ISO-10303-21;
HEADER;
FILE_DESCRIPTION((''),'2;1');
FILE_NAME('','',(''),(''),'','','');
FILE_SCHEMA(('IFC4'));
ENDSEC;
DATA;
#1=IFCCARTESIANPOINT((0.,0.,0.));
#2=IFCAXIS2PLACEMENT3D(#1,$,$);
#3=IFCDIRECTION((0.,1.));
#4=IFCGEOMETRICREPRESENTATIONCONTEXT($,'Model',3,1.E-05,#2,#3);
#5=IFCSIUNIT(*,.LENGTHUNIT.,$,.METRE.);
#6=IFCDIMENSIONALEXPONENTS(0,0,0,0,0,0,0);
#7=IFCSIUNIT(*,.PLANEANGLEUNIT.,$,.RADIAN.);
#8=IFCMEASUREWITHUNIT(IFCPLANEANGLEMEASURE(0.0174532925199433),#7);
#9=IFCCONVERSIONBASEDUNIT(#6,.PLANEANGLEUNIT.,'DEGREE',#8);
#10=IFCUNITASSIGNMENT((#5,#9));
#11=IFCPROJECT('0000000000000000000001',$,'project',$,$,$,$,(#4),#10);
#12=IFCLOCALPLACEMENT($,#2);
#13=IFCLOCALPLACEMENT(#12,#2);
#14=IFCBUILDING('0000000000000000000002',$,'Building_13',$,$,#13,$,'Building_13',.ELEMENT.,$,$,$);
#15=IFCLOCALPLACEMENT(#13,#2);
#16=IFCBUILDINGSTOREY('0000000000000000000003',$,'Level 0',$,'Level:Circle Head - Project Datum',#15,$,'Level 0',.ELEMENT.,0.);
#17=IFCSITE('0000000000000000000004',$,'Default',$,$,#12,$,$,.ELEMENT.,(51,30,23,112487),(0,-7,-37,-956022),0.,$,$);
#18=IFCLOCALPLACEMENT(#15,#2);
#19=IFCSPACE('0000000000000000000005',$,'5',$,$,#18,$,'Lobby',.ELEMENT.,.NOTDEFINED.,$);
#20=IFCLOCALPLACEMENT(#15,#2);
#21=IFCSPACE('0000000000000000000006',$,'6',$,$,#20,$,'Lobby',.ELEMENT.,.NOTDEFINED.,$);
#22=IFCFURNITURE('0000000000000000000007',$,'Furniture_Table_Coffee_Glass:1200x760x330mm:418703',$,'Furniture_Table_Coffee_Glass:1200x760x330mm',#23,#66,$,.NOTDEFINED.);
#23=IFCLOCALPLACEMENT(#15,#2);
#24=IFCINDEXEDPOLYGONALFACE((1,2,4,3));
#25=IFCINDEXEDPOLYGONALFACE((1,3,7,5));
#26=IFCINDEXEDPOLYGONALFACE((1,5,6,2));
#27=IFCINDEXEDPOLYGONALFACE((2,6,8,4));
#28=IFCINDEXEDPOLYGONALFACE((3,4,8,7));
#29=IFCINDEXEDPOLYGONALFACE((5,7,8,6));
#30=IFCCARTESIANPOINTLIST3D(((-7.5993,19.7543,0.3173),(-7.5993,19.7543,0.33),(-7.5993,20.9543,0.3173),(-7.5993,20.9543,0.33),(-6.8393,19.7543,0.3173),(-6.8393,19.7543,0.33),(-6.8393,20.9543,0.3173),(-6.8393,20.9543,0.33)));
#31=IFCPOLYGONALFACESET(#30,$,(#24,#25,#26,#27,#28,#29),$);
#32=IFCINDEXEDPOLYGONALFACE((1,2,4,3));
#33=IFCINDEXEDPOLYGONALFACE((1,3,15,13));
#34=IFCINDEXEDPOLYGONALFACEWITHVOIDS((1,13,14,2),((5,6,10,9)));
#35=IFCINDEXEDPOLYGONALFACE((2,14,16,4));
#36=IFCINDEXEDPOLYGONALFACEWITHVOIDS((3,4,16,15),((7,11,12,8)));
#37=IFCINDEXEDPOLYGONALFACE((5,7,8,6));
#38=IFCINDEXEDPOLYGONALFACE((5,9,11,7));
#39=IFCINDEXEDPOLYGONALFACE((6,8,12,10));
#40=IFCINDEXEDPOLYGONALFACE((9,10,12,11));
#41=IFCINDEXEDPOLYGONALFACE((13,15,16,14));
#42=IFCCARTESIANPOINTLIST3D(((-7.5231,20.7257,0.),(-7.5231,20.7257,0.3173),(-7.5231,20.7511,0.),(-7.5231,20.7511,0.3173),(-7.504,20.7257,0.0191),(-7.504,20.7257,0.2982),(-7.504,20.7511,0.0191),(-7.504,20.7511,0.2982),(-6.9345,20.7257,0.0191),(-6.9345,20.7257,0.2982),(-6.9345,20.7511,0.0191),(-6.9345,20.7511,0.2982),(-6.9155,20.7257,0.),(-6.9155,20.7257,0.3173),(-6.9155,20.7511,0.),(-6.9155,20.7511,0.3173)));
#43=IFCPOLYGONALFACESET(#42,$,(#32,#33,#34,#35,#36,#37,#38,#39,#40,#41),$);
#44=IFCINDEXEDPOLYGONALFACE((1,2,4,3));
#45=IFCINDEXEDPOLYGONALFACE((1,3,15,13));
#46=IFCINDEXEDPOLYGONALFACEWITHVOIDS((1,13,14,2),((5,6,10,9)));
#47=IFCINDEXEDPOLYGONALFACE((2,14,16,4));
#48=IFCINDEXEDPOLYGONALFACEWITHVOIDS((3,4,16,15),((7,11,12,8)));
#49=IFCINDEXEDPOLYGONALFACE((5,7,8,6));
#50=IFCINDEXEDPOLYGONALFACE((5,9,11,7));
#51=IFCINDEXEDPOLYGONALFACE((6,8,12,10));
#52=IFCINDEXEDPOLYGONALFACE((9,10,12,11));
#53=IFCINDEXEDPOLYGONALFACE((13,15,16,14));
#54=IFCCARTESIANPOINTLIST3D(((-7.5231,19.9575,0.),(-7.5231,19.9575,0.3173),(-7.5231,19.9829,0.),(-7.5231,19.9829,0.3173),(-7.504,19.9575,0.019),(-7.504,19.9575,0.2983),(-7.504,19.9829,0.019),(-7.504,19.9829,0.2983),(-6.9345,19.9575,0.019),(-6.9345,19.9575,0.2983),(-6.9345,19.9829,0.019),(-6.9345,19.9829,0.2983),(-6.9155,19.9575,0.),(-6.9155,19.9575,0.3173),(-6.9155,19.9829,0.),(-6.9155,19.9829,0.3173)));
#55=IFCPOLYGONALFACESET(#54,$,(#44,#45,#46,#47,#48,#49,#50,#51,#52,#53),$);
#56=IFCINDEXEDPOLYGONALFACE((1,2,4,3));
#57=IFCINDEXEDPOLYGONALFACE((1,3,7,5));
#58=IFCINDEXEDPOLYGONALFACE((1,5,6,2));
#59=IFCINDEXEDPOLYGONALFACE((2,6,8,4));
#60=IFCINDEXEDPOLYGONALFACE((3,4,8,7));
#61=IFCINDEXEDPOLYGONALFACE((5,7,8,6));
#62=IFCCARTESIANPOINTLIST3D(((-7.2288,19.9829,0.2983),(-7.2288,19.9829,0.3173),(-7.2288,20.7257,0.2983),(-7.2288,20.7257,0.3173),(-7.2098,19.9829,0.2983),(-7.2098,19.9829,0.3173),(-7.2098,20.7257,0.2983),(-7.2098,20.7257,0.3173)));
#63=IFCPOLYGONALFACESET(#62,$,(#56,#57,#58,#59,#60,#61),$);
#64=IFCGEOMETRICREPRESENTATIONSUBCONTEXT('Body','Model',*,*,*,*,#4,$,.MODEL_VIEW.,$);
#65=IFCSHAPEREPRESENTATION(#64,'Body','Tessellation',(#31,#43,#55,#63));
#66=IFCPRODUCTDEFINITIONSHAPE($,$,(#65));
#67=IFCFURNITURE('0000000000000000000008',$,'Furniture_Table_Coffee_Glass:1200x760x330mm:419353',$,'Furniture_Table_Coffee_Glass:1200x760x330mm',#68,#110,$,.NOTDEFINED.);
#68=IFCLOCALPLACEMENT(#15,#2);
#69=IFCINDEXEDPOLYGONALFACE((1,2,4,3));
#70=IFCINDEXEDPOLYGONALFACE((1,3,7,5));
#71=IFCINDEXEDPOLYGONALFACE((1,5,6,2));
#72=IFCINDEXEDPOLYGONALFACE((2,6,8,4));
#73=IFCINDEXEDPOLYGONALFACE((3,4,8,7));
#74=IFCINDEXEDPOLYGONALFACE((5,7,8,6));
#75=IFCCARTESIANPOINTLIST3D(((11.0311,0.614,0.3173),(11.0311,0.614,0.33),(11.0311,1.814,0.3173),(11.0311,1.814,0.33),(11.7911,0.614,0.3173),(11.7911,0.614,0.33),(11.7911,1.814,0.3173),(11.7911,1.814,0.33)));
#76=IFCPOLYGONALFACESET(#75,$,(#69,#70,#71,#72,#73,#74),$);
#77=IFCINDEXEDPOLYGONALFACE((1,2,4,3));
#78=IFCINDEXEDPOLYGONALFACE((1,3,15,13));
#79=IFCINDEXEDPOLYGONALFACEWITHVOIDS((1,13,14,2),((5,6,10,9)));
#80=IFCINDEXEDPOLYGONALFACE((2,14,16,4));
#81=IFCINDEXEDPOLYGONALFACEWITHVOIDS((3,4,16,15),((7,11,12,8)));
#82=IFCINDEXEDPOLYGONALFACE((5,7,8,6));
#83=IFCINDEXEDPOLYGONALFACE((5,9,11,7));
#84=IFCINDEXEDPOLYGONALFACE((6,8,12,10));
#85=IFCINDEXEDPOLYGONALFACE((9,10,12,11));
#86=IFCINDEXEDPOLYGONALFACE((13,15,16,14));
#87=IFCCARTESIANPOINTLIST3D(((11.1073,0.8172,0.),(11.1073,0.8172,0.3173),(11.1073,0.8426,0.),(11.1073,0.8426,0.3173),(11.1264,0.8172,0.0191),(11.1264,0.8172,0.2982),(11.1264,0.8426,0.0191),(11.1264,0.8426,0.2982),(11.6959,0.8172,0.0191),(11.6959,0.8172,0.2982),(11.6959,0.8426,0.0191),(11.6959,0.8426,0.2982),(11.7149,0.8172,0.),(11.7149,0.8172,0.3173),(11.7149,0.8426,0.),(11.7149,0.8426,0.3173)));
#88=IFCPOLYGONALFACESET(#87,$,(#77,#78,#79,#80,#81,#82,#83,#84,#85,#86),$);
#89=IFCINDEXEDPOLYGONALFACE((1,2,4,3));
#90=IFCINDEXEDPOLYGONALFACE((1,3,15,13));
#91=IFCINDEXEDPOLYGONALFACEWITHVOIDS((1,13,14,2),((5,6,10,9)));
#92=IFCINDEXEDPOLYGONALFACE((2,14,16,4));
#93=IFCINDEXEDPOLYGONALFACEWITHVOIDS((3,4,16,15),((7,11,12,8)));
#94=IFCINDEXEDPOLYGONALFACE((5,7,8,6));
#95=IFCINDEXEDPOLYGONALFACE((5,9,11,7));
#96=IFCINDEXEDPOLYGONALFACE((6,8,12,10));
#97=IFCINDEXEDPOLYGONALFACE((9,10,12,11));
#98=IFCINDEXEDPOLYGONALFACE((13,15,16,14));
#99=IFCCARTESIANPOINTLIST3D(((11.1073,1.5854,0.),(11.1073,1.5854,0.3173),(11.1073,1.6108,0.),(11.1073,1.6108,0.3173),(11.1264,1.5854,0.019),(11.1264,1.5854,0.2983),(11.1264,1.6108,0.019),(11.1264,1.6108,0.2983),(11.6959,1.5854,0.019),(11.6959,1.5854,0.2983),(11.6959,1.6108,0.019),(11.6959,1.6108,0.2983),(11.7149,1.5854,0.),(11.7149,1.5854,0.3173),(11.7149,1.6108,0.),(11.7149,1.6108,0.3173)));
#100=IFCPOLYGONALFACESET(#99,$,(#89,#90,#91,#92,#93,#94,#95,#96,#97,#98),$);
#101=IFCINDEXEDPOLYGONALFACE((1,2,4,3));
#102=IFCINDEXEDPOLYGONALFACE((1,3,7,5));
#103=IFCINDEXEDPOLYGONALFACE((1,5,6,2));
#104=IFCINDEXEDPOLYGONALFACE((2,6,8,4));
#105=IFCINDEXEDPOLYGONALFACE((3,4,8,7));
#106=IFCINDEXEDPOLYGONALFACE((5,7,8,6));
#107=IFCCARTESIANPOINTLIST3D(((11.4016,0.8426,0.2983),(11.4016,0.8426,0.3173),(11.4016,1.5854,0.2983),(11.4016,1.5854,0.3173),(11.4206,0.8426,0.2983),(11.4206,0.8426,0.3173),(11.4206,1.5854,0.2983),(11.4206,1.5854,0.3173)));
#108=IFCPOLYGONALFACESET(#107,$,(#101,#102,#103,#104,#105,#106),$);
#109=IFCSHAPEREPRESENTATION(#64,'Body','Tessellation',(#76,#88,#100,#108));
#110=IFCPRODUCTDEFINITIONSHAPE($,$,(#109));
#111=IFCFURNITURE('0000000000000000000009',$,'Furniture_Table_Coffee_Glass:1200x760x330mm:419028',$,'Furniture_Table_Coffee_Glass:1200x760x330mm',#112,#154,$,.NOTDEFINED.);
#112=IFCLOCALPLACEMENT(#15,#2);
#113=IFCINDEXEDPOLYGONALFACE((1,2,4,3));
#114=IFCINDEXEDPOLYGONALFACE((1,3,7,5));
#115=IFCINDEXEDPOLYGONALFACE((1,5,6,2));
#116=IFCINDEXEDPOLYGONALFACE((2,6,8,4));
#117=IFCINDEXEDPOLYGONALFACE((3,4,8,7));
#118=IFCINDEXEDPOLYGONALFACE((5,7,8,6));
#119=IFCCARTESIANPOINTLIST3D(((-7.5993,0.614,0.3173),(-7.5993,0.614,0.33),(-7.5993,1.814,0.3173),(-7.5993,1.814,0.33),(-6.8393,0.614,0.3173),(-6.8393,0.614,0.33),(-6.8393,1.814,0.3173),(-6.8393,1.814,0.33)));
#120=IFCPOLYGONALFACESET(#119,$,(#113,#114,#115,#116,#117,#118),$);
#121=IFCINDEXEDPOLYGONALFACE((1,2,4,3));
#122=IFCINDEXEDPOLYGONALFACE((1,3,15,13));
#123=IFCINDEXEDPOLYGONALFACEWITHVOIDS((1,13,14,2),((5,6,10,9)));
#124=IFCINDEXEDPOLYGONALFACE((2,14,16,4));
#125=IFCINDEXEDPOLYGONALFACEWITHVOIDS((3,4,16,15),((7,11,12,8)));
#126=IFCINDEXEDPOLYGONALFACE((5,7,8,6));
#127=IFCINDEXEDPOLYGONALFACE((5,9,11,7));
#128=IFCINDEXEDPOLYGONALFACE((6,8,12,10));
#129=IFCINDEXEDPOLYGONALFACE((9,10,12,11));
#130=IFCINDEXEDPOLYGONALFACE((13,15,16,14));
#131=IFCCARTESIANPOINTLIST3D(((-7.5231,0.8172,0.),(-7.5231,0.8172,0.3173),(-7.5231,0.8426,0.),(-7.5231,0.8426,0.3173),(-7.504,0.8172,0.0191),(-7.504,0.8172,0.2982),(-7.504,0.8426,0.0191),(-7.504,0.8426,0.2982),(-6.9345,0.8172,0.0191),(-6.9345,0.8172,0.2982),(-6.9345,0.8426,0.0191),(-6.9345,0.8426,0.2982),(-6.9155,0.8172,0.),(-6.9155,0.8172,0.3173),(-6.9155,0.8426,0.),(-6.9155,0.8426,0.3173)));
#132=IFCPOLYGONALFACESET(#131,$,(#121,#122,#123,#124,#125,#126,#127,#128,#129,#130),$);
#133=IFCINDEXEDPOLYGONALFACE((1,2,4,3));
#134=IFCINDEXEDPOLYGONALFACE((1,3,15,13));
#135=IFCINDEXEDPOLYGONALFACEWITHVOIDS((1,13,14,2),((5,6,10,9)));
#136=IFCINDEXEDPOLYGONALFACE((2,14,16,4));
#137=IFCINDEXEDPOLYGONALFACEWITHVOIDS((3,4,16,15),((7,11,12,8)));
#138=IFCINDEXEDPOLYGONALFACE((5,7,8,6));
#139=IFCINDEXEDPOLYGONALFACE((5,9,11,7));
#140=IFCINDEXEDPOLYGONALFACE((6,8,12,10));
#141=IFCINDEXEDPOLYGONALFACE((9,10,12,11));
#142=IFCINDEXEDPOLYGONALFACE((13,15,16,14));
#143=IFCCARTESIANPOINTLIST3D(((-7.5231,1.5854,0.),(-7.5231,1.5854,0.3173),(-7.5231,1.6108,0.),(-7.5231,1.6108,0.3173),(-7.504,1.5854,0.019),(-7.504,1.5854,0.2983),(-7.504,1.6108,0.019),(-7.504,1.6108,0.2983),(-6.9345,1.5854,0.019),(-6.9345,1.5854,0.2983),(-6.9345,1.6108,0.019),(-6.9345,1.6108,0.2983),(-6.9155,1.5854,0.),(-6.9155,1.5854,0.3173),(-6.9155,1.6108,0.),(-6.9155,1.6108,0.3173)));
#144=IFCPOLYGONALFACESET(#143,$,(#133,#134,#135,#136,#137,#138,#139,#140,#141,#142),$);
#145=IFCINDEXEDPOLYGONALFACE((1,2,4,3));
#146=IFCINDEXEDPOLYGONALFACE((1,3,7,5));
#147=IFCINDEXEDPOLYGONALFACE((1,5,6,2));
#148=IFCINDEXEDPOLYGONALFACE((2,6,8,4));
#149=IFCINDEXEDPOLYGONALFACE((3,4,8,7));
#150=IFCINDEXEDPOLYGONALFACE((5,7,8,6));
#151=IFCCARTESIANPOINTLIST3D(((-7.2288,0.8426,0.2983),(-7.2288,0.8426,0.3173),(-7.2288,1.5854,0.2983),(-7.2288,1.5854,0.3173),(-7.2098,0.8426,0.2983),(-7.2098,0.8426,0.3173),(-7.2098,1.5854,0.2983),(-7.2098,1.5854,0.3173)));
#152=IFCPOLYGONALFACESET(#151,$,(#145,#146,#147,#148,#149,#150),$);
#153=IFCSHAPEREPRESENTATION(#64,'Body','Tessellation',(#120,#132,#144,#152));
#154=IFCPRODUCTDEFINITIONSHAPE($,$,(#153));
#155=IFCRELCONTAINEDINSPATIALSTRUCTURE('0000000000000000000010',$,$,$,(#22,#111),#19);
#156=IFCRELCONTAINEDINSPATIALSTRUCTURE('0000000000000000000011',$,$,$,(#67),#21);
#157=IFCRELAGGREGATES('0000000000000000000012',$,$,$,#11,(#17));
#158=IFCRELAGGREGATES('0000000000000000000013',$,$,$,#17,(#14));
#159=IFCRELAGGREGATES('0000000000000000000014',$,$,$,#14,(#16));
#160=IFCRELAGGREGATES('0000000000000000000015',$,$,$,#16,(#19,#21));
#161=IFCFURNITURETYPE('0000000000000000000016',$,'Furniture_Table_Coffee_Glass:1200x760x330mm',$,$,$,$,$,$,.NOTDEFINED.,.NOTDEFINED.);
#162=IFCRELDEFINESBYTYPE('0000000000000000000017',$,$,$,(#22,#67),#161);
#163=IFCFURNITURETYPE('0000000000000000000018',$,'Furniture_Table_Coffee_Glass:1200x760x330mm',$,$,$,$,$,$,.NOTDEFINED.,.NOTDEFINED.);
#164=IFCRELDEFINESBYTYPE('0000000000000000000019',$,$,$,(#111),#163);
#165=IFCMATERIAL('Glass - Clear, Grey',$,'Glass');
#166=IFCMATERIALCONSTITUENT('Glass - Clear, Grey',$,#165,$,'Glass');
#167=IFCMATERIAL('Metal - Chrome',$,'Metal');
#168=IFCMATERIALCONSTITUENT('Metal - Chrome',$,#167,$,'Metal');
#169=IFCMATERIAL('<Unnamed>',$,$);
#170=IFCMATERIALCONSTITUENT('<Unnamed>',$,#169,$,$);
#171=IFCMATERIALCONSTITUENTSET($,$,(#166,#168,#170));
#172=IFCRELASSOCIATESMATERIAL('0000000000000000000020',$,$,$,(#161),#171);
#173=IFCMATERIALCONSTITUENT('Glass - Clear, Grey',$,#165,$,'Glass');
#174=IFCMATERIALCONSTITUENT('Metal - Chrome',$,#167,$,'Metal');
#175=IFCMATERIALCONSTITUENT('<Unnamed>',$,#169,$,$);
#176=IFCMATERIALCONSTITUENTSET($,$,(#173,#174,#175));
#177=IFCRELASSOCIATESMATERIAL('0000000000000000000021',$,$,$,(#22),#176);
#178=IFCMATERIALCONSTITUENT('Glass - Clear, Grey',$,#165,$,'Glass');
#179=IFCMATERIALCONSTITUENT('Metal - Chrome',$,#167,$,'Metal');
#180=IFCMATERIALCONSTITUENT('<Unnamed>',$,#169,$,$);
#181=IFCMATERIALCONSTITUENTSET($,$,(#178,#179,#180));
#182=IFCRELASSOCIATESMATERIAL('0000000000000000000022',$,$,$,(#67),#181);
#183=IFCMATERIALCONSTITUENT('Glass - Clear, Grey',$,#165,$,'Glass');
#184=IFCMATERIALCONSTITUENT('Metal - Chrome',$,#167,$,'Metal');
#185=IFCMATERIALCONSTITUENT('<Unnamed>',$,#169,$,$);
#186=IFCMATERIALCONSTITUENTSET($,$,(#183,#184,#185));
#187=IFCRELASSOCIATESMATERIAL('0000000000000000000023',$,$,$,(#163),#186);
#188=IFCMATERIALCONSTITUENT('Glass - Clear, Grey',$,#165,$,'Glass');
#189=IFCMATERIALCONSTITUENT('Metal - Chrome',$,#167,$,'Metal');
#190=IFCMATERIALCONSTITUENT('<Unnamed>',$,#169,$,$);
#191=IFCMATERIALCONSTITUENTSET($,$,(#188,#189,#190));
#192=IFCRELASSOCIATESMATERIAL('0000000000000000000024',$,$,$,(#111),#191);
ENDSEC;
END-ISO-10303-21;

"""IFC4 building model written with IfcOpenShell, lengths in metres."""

from ifc_helpers import new_model, entity, si_unit, converted_unit, direction, frame, origin, place, context, subcontext, project, spatial, indexed_curve, outline, extrude, source, transform, mapped, material, constituent, constituent_set, type_object, type_shapes, element, save


model = new_model("IFC4")

# Units and contexts
model_context = context("Model", 3, precision=1e-05, world=origin(), true_north=direction((0.0, 1.0)))
body_context = subcontext(model_context, "Body", "Model", "MODEL_VIEW")
ifc_project = project(units=[si_unit("LENGTHUNIT", "METRE"), converted_unit("PLANEANGLEUNIT", "DEGREE", entity("IfcPlaneAngleMeasure", 0.0174532925199433), si_unit("PLANEANGLEUNIT", "RADIAN"), dimensions=[0, 0, 0, 0, 0, 0, 0])], contexts=[model_context])

# Site, building, storey
site_placement = place(None, origin())
site = spatial("IfcSite", under=ifc_project, at=site_placement, Name="Default", CompositionType="ELEMENT", RefLatitude=(51, 30, 23, 112487), RefLongitude=(0, -7, -37, -956022), RefElevation=0.0)
building_placement = place(site_placement, origin())
building = spatial("IfcBuilding", under=site, at=building_placement, Name="Building_13", LongName="Building_13", CompositionType="ELEMENT")
storey_placement = place(building_placement, origin())
storey = spatial("IfcBuildingStorey", under=building, at=storey_placement, Name="Level 0", ObjectType="Level:Circle Head - Project Datum", LongName="Level 0", CompositionType="ELEMENT", Elevation=0.0)

# Shared definitions
space_1_placement = place(storey_placement, origin())
space_1 = spatial("IfcSpace", under=storey, at=space_1_placement, Name="5", LongName="Lobby", CompositionType="ELEMENT", PredefinedType="NOTDEFINED")

# Furniture
ifc_material_1 = material(Name="Glass - Clear, Grey", Category="Glass")
ifc_constituent_1 = constituent(ifc_material_1, Name="Glass - Clear, Grey", Category="Glass")
ifc_material_2 = material(Name="Metal - Chrome", Category="Metal")
ifc_constituent_2 = constituent(ifc_material_2, Name="Metal - Chrome", Category="Metal")
ifc_material_3 = material(Name="<Unnamed>")
ifc_constituent_3 = constituent(ifc_material_3, Name="<Unnamed>")
ifc_constituent_set_1 = constituent_set(constituents=[ifc_constituent_1, ifc_constituent_2, ifc_constituent_3])
ifc_constituent_4 = constituent(ifc_material_1, Name="Glass - Clear, Grey", Category="Glass")
ifc_constituent_5 = constituent(ifc_material_2, Name="Metal - Chrome", Category="Metal")
ifc_constituent_6 = constituent(ifc_material_3, Name="<Unnamed>")
ifc_constituent_set_2 = constituent_set(constituents=[ifc_constituent_4, ifc_constituent_5, ifc_constituent_6])
furniture_type_1 = type_object("IfcFurnitureType", Name="Furniture_Table_Coffee_Glass:1200x760x330mm", AssemblyPlace="NOTDEFINED", PredefinedType="NOTDEFINED", material=ifc_constituent_set_2)
shared_shape_1 = source(origin(), body_context, "Body", "SweptSolid", [
    extrude(outline(indexed_curve([(-0.6, -0.38), (0.6, -0.38), (0.6, 0.38), (-0.6, 0.38), (-0.6, -0.38)], self_intersect=False)), frame((0.6037, 0.3686, 0.3173), z_axis=(0.0, 0.0, 1.0), x_axis=(-1.0, 0.0, 0.0)), (0.0, 0.0, 1.0), 0.0127),
    extrude(outline(indexed_curve([(-0.1587, -0.3038), (0.1587, -0.3038), (0.1587, 0.3038), (-0.1587, 0.3038), (-0.1587, -0.3038)], self_intersect=False), holes=[indexed_curve([(-0.1396, -0.2848), (-0.1396, 0.2848), (0.1396, 0.2848), (0.1396, -0.2848), (-0.1396, -0.2848)], self_intersect=False)]), frame((0.2069, 0.3686, 0.1587), z_axis=(1.0, 0.0, 0.0), x_axis=(0.0, 0.0, -1.0)), (0.0, 0.0, 1.0), 0.0254),
    extrude(outline(indexed_curve([(-0.1586, -0.3038), (0.1586, -0.3038), (0.1586, 0.3038), (-0.1586, 0.3038), (-0.1586, -0.3038)], self_intersect=False), holes=[indexed_curve([(-0.1396, -0.2848), (-0.1396, 0.2848), (0.1396, 0.2848), (0.1396, -0.2848), (-0.1396, -0.2848)], self_intersect=False)]), frame((0.9751, 0.3686, 0.1586), z_axis=(1.0, 0.0, 0.0), x_axis=(0.0, 0.0, -1.0)), (0.0, 0.0, 1.0), 0.0254),
    extrude(outline(indexed_curve([(-0.3714, -0.0095), (0.3714, -0.0095), (0.3714, 0.0095), (-0.3714, 0.0095), (-0.3714, -0.0095)], self_intersect=False)), frame((0.6037, 0.3686, 0.2983), z_axis=(0.0, 0.0, 1.0), x_axis=(-1.0, 0.0, 0.0)), (0.0, 0.0, 1.0), 0.0191),
])
type_shapes(furniture_type_1, [shared_shape_1])
furniture_1_placement = place(space_1_placement, frame((-7.5879, 20.9581, 0.0), z_axis=(0.0, 0.0, 1.0), x_axis=(0.0, -1.0, 0.0)))
element("IfcFurniture", 1, at=furniture_1_placement, inside=space_1, type_object=furniture_type_1, material=ifc_constituent_set_1, Name="Furniture_Table_Coffee_Glass:1200x760x330mm:418703", ObjectType="Furniture_Table_Coffee_Glass:1200x760x330mm", PredefinedType="NOTDEFINED", context=body_context, shape_type="MappedRepresentation", body=[
    mapped(shared_shape_1, transform((0.0, 0.0, 0.0), scale=1.0)),
])

# Shared definitions
space_2_placement = place(storey_placement, origin())
space_2 = spatial("IfcSpace", under=storey, at=space_2_placement, Name="6", LongName="Lobby", CompositionType="ELEMENT", PredefinedType="NOTDEFINED")

# Furniture
ifc_constituent_7 = constituent(ifc_material_1, Name="Glass - Clear, Grey", Category="Glass")
ifc_constituent_8 = constituent(ifc_material_2, Name="Metal - Chrome", Category="Metal")
ifc_constituent_9 = constituent(ifc_material_3, Name="<Unnamed>")
ifc_constituent_set_3 = constituent_set(constituents=[ifc_constituent_7, ifc_constituent_8, ifc_constituent_9])
furniture_2_placement = place(space_2_placement, frame((11.7797, 0.6103, 0.0), z_axis=(0.0, 0.0, 1.0), x_axis=(0.0, 1.0, 0.0)))
element("IfcFurniture", 2, at=furniture_2_placement, inside=space_2, type_object=furniture_type_1, material=ifc_constituent_set_3, Name="Furniture_Table_Coffee_Glass:1200x760x330mm:419353", ObjectType="Furniture_Table_Coffee_Glass:1200x760x330mm", PredefinedType="NOTDEFINED", context=body_context, shape_type="MappedRepresentation", body=[
    mapped(shared_shape_1, transform((0.0, 0.0, 0.0), scale=1.0)),
])
ifc_constituent_10 = constituent(ifc_material_1, Name="Glass - Clear, Grey", Category="Glass")
ifc_constituent_11 = constituent(ifc_material_2, Name="Metal - Chrome", Category="Metal")
ifc_constituent_12 = constituent(ifc_material_3, Name="<Unnamed>")
ifc_constituent_set_4 = constituent_set(constituents=[ifc_constituent_10, ifc_constituent_11, ifc_constituent_12])
ifc_constituent_13 = constituent(ifc_material_1, Name="Glass - Clear, Grey", Category="Glass")
ifc_constituent_14 = constituent(ifc_material_2, Name="Metal - Chrome", Category="Metal")
ifc_constituent_15 = constituent(ifc_material_3, Name="<Unnamed>")
ifc_constituent_set_5 = constituent_set(constituents=[ifc_constituent_13, ifc_constituent_14, ifc_constituent_15])
furniture_type_2 = type_object("IfcFurnitureType", Name="Furniture_Table_Coffee_Glass:1200x760x330mm", AssemblyPlace="NOTDEFINED", PredefinedType="NOTDEFINED", material=ifc_constituent_set_5)
shared_shape_2 = source(origin(), body_context, "Body", "SweptSolid", [
    extrude(outline(indexed_curve([(-0.38, -0.6), (0.38, -0.6), (0.38, 0.6), (-0.38, 0.6), (-0.38, -0.6)], self_intersect=False)), frame((0.6037, -0.3686, 0.3173), z_axis=(0.0, 0.0, 1.0), x_axis=(0.0, 1.0, 0.0)), (0.0, 0.0, 1.0), 0.0127),
    extrude(outline(indexed_curve([(-0.3038, -0.1587), (0.3038, -0.1587), (0.3038, 0.1587), (-0.3038, 0.1587), (-0.3038, -0.1587)], self_intersect=False), holes=[indexed_curve([(-0.2848, -0.1396), (-0.2848, 0.1396), (0.2848, 0.1396), (0.2848, -0.1396), (-0.2848, -0.1396)], self_intersect=False)]), frame((0.2069, -0.3686, 0.1587), z_axis=(1.0, 0.0, 0.0), x_axis=(0.0, -1.0, 0.0)), (0.0, 0.0, 1.0), 0.0254),
    extrude(outline(indexed_curve([(-0.3038, -0.1586), (0.3038, -0.1586), (0.3038, 0.1586), (-0.3038, 0.1586), (-0.3038, -0.1586)], self_intersect=False), holes=[indexed_curve([(-0.2848, -0.1396), (-0.2848, 0.1396), (0.2848, 0.1396), (0.2848, -0.1396), (-0.2848, -0.1396)], self_intersect=False)]), frame((0.9751, -0.3686, 0.1586), z_axis=(1.0, 0.0, 0.0), x_axis=(0.0, -1.0, 0.0)), (0.0, 0.0, 1.0), 0.0254),
    extrude(outline(indexed_curve([(-0.0095, -0.3714), (0.0095, -0.3714), (0.0095, 0.3714), (-0.0095, 0.3714), (-0.0095, -0.3714)], self_intersect=False)), frame((0.6037, -0.3686, 0.2983), z_axis=(0.0, 0.0, 1.0), x_axis=(0.0, 1.0, 0.0)), (0.0, 0.0, 1.0), 0.0191),
])
type_shapes(furniture_type_2, [shared_shape_2])
furniture_3_placement = place(space_1_placement, frame((-7.5879, 0.6103, 0.0), z_axis=(0.0, 0.0, 1.0), x_axis=(0.0, 1.0, 0.0)))
element("IfcFurniture", 3, at=furniture_3_placement, inside=space_1, type_object=furniture_type_2, material=ifc_constituent_set_4, Name="Furniture_Table_Coffee_Glass:1200x760x330mm:419028", ObjectType="Furniture_Table_Coffee_Glass:1200x760x330mm", PredefinedType="NOTDEFINED", context=body_context, shape_type="MappedRepresentation", body=[
    mapped(shared_shape_2, transform((0.0, 0.0, 0.0), scale=1.0)),
])

save(model, "model.ifc")
